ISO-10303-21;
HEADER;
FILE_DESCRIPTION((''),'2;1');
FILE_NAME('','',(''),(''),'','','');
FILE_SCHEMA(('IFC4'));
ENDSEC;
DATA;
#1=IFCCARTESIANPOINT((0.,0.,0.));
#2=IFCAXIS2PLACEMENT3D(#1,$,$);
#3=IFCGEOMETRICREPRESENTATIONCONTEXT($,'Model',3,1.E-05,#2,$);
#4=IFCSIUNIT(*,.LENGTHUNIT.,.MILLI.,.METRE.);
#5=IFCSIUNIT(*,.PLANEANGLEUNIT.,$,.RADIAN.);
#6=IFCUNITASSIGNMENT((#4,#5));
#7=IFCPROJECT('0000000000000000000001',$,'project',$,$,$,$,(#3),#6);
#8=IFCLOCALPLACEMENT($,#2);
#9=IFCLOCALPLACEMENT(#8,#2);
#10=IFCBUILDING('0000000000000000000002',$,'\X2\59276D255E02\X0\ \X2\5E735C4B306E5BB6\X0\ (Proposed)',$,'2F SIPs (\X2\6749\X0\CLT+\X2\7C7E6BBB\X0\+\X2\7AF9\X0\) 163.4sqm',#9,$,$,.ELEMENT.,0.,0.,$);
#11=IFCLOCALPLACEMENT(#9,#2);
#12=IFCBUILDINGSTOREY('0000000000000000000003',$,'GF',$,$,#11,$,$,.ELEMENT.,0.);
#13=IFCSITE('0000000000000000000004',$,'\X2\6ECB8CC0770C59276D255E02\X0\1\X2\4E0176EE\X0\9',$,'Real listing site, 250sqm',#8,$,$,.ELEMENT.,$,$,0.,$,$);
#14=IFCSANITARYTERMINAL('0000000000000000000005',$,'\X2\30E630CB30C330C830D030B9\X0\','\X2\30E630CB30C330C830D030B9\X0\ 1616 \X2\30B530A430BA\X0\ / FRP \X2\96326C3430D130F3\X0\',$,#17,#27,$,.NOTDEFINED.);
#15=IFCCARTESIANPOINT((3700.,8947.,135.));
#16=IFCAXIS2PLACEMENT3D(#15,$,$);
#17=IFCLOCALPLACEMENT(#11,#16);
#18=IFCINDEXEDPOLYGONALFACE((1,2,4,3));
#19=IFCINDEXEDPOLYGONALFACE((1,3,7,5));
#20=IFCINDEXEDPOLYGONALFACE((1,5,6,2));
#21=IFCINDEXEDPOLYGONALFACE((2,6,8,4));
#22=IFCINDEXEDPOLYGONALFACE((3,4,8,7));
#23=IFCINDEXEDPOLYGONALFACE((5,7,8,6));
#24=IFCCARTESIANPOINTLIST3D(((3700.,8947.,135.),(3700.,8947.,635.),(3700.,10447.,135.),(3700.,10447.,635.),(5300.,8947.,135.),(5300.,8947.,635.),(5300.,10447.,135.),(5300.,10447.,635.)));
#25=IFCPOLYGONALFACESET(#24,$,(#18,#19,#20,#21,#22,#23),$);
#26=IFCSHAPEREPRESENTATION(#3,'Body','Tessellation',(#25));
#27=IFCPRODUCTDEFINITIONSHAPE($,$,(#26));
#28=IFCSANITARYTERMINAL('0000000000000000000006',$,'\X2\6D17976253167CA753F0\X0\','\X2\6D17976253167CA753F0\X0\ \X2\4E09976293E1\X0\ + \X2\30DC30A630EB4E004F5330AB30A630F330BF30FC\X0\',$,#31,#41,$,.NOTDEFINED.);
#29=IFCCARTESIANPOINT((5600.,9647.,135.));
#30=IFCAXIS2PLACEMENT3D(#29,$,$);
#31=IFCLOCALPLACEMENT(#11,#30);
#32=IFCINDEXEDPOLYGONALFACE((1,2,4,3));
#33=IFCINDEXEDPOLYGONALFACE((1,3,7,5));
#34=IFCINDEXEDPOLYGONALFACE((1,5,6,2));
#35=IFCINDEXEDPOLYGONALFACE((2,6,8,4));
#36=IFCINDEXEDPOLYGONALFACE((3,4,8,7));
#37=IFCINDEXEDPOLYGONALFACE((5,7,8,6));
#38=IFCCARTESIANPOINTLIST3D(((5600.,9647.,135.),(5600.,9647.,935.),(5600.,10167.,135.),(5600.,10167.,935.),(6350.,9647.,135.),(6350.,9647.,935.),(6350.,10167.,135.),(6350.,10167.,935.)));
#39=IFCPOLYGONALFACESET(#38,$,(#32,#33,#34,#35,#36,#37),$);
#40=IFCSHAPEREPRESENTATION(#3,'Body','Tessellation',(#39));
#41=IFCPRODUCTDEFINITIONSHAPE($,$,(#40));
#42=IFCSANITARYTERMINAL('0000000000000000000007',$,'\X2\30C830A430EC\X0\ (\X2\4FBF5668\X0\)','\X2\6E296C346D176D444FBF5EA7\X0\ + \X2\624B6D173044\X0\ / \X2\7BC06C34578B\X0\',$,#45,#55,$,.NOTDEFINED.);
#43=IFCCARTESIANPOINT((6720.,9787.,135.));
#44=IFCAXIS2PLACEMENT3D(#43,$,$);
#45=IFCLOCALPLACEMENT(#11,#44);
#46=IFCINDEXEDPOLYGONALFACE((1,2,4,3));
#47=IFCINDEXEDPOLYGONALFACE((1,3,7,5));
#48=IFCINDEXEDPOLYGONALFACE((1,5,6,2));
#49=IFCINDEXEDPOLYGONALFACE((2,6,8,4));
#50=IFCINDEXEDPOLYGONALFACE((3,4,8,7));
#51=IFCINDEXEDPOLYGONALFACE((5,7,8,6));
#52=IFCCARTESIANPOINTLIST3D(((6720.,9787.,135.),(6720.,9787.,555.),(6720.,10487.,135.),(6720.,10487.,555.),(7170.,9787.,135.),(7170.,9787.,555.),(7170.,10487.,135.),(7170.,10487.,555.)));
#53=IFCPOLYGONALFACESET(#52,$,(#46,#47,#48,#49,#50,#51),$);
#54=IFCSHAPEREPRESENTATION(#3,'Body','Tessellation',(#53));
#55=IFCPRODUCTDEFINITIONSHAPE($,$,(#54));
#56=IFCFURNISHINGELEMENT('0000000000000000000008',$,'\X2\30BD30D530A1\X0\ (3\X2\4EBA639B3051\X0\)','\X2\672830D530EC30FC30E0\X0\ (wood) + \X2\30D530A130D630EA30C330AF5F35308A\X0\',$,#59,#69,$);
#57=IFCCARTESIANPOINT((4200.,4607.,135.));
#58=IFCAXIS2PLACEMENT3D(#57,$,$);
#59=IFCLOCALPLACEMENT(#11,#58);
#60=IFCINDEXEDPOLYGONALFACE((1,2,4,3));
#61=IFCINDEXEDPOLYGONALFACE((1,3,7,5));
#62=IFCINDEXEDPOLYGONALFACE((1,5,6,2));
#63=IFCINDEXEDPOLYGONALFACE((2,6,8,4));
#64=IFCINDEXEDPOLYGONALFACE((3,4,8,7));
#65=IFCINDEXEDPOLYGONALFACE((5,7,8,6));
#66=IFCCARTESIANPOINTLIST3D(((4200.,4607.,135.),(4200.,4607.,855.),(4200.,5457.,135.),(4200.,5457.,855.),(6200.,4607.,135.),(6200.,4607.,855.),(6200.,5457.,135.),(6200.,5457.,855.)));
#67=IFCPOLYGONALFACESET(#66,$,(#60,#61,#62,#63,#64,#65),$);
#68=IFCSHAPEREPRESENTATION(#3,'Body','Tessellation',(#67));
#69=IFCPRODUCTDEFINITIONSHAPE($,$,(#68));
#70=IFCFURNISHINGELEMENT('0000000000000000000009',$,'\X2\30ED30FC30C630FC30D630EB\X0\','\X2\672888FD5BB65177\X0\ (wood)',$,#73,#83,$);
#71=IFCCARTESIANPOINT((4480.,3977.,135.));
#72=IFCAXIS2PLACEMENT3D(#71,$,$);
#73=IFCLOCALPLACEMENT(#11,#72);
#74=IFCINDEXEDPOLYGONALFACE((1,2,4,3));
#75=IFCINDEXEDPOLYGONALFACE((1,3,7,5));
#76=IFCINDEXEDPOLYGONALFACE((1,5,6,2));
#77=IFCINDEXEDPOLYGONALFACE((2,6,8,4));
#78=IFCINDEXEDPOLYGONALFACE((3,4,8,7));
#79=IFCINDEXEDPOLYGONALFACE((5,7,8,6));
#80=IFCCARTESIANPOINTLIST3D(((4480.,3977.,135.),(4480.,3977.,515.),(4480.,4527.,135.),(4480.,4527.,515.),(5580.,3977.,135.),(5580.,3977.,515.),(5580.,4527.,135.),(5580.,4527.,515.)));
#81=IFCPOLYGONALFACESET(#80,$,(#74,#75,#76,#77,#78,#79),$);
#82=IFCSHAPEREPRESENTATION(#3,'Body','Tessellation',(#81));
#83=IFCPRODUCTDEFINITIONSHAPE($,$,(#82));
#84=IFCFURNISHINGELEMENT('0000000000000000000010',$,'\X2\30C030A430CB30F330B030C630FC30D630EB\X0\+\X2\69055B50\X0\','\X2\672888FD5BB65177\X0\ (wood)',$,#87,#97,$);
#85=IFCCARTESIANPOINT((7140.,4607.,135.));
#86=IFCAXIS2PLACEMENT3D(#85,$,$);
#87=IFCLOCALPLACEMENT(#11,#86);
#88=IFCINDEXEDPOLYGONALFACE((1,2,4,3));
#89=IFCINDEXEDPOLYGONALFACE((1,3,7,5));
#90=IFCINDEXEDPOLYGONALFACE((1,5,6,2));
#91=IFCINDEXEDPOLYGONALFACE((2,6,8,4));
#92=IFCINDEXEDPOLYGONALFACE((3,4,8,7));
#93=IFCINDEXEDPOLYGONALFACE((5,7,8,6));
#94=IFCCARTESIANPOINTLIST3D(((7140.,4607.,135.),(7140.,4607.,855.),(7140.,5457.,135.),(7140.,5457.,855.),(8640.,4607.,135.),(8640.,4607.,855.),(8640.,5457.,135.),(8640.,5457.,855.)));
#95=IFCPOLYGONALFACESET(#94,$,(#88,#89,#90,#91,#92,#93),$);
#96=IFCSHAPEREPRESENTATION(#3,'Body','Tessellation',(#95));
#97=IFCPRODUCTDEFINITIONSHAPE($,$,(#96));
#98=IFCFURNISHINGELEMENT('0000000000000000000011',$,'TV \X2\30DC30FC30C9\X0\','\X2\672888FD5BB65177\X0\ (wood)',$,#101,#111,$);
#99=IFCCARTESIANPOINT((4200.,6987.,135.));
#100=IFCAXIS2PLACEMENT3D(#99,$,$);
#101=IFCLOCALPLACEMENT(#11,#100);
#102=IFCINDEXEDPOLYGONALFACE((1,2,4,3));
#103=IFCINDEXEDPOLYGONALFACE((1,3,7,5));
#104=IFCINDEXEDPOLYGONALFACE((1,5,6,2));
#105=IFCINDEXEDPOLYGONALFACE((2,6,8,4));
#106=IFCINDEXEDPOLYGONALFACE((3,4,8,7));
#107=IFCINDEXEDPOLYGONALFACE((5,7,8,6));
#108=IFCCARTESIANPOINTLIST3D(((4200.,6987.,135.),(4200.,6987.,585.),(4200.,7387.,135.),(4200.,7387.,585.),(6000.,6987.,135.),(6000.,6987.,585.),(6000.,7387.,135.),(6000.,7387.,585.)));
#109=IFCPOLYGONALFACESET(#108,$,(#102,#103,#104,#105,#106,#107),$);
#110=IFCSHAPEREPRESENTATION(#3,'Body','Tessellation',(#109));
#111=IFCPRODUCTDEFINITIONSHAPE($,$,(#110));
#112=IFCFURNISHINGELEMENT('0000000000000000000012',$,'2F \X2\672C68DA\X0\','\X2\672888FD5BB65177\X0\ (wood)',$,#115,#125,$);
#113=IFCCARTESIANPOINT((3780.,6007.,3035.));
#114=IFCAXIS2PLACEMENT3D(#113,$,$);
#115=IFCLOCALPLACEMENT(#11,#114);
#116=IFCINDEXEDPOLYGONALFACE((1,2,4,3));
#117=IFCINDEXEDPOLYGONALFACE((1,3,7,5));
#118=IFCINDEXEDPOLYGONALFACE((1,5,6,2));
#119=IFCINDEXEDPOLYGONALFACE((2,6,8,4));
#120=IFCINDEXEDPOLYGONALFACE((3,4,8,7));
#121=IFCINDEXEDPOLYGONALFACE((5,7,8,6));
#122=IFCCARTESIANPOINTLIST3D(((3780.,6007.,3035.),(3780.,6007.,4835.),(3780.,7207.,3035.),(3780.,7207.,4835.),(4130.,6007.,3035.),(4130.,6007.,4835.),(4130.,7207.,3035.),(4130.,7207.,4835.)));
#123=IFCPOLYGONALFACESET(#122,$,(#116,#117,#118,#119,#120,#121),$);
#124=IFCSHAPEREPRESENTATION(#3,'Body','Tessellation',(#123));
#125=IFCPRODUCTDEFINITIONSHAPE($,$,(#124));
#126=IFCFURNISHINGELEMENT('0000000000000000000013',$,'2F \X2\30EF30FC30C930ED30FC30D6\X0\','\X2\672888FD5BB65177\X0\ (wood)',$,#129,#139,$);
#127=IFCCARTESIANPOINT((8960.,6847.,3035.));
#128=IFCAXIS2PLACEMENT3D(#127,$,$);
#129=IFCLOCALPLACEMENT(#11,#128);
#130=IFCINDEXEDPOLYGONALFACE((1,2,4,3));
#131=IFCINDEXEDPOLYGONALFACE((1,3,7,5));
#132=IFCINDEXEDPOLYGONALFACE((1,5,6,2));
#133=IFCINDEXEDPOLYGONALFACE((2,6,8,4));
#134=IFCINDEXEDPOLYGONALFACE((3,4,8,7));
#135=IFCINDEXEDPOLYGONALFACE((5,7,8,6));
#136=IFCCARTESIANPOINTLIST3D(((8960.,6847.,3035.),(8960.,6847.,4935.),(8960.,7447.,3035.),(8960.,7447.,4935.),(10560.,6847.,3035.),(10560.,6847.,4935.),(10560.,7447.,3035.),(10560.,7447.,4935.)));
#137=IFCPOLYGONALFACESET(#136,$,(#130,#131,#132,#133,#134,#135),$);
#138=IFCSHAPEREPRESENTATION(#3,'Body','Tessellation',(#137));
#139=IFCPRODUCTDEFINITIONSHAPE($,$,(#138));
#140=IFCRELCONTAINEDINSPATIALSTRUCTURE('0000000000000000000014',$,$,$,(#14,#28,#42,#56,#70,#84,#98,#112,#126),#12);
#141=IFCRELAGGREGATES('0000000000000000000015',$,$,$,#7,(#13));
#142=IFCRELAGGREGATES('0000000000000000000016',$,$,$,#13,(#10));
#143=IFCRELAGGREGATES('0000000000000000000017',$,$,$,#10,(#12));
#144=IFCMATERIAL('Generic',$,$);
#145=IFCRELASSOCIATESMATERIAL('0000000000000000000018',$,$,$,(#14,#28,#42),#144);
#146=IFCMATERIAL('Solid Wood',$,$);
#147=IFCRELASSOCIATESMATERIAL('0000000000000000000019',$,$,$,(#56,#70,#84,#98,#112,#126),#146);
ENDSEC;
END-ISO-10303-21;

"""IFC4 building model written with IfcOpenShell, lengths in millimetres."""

from ifc_helpers import new_model, si_unit, frame, frame_2d, origin, place, context, project, spatial, rectangle, extrude, material, element, save


model = new_model("IFC4")

# Units and contexts
model_context = context("Model", 3, precision=1e-05, world=origin())
ifc_project = project(units=[si_unit("LENGTHUNIT", "METRE", prefix="MILLI"), si_unit("PLANEANGLEUNIT", "RADIAN")], contexts=[model_context])

# Site, building, storey
site_placement = place(None, origin())
site = spatial("IfcSite", under=ifc_project, at=site_placement, Name="滋賀県大津市1丁目9", ObjectType="Real listing site, 250sqm", CompositionType="ELEMENT", RefElevation=0.0)
building_placement = place(site_placement, origin())
building = spatial("IfcBuilding", under=site, at=building_placement, Name="大津市 平屋の家 (Proposed)", ObjectType="2F SIPs (杉CLT+籾殻+竹) 163.4sqm", CompositionType="ELEMENT", ElevationOfRefHeight=0.0, ElevationOfTerrain=0.0)
storey_placement = place(building_placement, origin())
storey = spatial("IfcBuildingStorey", under=building, at=storey_placement, Name="GF", CompositionType="ELEMENT", Elevation=0.0)

# Shared definitions
ifc_material_1 = material(Name="Generic")

# Shared definitions
ifc_material_2 = material(Name="Solid Wood")

# Sanitary terminals
sanitary_terminal_1_placement = place(storey_placement, frame((3700.0, 8947.0, 135.0)))
element("IfcSanitaryTerminal", 1, at=sanitary_terminal_1_placement, inside=storey, material=ifc_material_1, Name="ユニットバス", Description="ユニットバス 1616 サイズ / FRP 防水パン", PredefinedType="NOTDEFINED", context=model_context, shape_type="SweptSolid", body=[
    extrude(rectangle(XDim=1600.0, YDim=1500.0, at=frame_2d((800.0, 750.0))), frame((3700.0, 8947.0, 135.0)), (0.0, 0.0, 1.0), 500.0),
])
sanitary_terminal_2_placement = place(storey_placement, frame((5600.0, 9647.0, 135.0)))
element("IfcSanitaryTerminal", 2, at=sanitary_terminal_2_placement, inside=storey, material=ifc_material_1, Name="洗面化粧台", Description="洗面化粧台 三面鏡 + ボウル一体カウンター", PredefinedType="NOTDEFINED", context=model_context, shape_type="SweptSolid", body=[
    extrude(rectangle(XDim=750.0, YDim=520.0, at=frame_2d((375.0, 260.0))), frame((5600.0, 9647.0, 135.0)), (0.0, 0.0, 1.0), 800.0),
])
sanitary_terminal_3_placement = place(storey_placement, frame((6720.0, 9787.0, 135.0)))
element("IfcSanitaryTerminal", 3, at=sanitary_terminal_3_placement, inside=storey, material=ifc_material_1, Name="トイレ (便器)", Description="温水洗浄便座 + 手洗い / 節水型", PredefinedType="NOTDEFINED", context=model_context, shape_type="SweptSolid", body=[
    extrude(rectangle(XDim=450.0, YDim=700.0, at=frame_2d((225.0, 350.0))), frame((6720.0, 9787.0, 135.0)), (0.0, 0.0, 1.0), 420.0),
])

# Furnishing elements
furnishing_1_placement = place(storey_placement, frame((4200.0, 4607.0, 135.0)))
element("IfcFurnishingElement", 4, at=furnishing_1_placement, inside=storey, material=ifc_material_2, Name="ソファ (3人掛け)", Description="木フレーム (wood) + ファブリック張り", context=model_context, shape_type="SweptSolid", body=[
    extrude(rectangle(XDim=2000.0, YDim=850.0, at=frame_2d((1000.0, 425.0))), frame((4200.0, 4607.0, 135.0)), (0.0, 0.0, 1.0), 720.0),
])
furnishing_2_placement = place(storey_placement, frame((4480.0, 3977.0, 135.0)))
element("IfcFurnishingElement", 5, at=furnishing_2_placement, inside=storey, material=ifc_material_2, Name="ローテーブル", Description="木製家具 (wood)", context=model_context, shape_type="SweptSolid", body=[
    extrude(rectangle(XDim=1100.0, YDim=550.0, at=frame_2d((550.0, 275.0))), frame((4480.0, 3977.0, 135.0)), (0.0, 0.0, 1.0), 380.0),
])
furnishing_3_placement = place(storey_placement, frame((7140.0, 4607.0, 135.0)))
element("IfcFurnishingElement", 6, at=furnishing_3_placement, inside=storey, material=ifc_material_2, Name="ダイニングテーブル+椅子", Description="木製家具 (wood)", context=model_context, shape_type="SweptSolid", body=[
    extrude(rectangle(XDim=1500.0, YDim=850.0, at=frame_2d((750.0, 425.0))), frame((7140.0, 4607.0, 135.0)), (0.0, 0.0, 1.0), 720.0),
])
furnishing_4_placement = place(storey_placement, frame((4200.0, 6987.0, 135.0)))
element("IfcFurnishingElement", 7, at=furnishing_4_placement, inside=storey, material=ifc_material_2, Name="TV ボード", Description="木製家具 (wood)", context=model_context, shape_type="SweptSolid", body=[
    extrude(rectangle(XDim=1800.0, YDim=400.0, at=frame_2d((900.0, 200.0))), frame((4200.0, 6987.0, 135.0)), (0.0, 0.0, 1.0), 450.0),
])
furnishing_5_placement = place(storey_placement, frame((3780.0, 6007.0, 3035.0)))
element("IfcFurnishingElement", 8, at=furnishing_5_placement, inside=storey, material=ifc_material_2, Name="2F 本棚", Description="木製家具 (wood)", context=model_context, shape_type="SweptSolid", body=[
    extrude(rectangle(XDim=350.0, YDim=1200.0, at=frame_2d((175.0, 600.0))), frame((3780.0, 6007.0, 3035.0)), (0.0, 0.0, 1.0), 1800.0),
])
furnishing_6_placement = place(storey_placement, frame((8960.0, 6847.0, 3035.0)))
element("IfcFurnishingElement", 9, at=furnishing_6_placement, inside=storey, material=ifc_material_2, Name="2F ワードローブ", Description="木製家具 (wood)", context=model_context, shape_type="SweptSolid", body=[
    extrude(rectangle(XDim=1600.0, YDim=600.0, at=frame_2d((800.0, 300.0))), frame((8960.0, 6847.0, 3035.0)), (0.0, 0.0, 1.0), 1900.0),
])

save(model, "model.ifc")
